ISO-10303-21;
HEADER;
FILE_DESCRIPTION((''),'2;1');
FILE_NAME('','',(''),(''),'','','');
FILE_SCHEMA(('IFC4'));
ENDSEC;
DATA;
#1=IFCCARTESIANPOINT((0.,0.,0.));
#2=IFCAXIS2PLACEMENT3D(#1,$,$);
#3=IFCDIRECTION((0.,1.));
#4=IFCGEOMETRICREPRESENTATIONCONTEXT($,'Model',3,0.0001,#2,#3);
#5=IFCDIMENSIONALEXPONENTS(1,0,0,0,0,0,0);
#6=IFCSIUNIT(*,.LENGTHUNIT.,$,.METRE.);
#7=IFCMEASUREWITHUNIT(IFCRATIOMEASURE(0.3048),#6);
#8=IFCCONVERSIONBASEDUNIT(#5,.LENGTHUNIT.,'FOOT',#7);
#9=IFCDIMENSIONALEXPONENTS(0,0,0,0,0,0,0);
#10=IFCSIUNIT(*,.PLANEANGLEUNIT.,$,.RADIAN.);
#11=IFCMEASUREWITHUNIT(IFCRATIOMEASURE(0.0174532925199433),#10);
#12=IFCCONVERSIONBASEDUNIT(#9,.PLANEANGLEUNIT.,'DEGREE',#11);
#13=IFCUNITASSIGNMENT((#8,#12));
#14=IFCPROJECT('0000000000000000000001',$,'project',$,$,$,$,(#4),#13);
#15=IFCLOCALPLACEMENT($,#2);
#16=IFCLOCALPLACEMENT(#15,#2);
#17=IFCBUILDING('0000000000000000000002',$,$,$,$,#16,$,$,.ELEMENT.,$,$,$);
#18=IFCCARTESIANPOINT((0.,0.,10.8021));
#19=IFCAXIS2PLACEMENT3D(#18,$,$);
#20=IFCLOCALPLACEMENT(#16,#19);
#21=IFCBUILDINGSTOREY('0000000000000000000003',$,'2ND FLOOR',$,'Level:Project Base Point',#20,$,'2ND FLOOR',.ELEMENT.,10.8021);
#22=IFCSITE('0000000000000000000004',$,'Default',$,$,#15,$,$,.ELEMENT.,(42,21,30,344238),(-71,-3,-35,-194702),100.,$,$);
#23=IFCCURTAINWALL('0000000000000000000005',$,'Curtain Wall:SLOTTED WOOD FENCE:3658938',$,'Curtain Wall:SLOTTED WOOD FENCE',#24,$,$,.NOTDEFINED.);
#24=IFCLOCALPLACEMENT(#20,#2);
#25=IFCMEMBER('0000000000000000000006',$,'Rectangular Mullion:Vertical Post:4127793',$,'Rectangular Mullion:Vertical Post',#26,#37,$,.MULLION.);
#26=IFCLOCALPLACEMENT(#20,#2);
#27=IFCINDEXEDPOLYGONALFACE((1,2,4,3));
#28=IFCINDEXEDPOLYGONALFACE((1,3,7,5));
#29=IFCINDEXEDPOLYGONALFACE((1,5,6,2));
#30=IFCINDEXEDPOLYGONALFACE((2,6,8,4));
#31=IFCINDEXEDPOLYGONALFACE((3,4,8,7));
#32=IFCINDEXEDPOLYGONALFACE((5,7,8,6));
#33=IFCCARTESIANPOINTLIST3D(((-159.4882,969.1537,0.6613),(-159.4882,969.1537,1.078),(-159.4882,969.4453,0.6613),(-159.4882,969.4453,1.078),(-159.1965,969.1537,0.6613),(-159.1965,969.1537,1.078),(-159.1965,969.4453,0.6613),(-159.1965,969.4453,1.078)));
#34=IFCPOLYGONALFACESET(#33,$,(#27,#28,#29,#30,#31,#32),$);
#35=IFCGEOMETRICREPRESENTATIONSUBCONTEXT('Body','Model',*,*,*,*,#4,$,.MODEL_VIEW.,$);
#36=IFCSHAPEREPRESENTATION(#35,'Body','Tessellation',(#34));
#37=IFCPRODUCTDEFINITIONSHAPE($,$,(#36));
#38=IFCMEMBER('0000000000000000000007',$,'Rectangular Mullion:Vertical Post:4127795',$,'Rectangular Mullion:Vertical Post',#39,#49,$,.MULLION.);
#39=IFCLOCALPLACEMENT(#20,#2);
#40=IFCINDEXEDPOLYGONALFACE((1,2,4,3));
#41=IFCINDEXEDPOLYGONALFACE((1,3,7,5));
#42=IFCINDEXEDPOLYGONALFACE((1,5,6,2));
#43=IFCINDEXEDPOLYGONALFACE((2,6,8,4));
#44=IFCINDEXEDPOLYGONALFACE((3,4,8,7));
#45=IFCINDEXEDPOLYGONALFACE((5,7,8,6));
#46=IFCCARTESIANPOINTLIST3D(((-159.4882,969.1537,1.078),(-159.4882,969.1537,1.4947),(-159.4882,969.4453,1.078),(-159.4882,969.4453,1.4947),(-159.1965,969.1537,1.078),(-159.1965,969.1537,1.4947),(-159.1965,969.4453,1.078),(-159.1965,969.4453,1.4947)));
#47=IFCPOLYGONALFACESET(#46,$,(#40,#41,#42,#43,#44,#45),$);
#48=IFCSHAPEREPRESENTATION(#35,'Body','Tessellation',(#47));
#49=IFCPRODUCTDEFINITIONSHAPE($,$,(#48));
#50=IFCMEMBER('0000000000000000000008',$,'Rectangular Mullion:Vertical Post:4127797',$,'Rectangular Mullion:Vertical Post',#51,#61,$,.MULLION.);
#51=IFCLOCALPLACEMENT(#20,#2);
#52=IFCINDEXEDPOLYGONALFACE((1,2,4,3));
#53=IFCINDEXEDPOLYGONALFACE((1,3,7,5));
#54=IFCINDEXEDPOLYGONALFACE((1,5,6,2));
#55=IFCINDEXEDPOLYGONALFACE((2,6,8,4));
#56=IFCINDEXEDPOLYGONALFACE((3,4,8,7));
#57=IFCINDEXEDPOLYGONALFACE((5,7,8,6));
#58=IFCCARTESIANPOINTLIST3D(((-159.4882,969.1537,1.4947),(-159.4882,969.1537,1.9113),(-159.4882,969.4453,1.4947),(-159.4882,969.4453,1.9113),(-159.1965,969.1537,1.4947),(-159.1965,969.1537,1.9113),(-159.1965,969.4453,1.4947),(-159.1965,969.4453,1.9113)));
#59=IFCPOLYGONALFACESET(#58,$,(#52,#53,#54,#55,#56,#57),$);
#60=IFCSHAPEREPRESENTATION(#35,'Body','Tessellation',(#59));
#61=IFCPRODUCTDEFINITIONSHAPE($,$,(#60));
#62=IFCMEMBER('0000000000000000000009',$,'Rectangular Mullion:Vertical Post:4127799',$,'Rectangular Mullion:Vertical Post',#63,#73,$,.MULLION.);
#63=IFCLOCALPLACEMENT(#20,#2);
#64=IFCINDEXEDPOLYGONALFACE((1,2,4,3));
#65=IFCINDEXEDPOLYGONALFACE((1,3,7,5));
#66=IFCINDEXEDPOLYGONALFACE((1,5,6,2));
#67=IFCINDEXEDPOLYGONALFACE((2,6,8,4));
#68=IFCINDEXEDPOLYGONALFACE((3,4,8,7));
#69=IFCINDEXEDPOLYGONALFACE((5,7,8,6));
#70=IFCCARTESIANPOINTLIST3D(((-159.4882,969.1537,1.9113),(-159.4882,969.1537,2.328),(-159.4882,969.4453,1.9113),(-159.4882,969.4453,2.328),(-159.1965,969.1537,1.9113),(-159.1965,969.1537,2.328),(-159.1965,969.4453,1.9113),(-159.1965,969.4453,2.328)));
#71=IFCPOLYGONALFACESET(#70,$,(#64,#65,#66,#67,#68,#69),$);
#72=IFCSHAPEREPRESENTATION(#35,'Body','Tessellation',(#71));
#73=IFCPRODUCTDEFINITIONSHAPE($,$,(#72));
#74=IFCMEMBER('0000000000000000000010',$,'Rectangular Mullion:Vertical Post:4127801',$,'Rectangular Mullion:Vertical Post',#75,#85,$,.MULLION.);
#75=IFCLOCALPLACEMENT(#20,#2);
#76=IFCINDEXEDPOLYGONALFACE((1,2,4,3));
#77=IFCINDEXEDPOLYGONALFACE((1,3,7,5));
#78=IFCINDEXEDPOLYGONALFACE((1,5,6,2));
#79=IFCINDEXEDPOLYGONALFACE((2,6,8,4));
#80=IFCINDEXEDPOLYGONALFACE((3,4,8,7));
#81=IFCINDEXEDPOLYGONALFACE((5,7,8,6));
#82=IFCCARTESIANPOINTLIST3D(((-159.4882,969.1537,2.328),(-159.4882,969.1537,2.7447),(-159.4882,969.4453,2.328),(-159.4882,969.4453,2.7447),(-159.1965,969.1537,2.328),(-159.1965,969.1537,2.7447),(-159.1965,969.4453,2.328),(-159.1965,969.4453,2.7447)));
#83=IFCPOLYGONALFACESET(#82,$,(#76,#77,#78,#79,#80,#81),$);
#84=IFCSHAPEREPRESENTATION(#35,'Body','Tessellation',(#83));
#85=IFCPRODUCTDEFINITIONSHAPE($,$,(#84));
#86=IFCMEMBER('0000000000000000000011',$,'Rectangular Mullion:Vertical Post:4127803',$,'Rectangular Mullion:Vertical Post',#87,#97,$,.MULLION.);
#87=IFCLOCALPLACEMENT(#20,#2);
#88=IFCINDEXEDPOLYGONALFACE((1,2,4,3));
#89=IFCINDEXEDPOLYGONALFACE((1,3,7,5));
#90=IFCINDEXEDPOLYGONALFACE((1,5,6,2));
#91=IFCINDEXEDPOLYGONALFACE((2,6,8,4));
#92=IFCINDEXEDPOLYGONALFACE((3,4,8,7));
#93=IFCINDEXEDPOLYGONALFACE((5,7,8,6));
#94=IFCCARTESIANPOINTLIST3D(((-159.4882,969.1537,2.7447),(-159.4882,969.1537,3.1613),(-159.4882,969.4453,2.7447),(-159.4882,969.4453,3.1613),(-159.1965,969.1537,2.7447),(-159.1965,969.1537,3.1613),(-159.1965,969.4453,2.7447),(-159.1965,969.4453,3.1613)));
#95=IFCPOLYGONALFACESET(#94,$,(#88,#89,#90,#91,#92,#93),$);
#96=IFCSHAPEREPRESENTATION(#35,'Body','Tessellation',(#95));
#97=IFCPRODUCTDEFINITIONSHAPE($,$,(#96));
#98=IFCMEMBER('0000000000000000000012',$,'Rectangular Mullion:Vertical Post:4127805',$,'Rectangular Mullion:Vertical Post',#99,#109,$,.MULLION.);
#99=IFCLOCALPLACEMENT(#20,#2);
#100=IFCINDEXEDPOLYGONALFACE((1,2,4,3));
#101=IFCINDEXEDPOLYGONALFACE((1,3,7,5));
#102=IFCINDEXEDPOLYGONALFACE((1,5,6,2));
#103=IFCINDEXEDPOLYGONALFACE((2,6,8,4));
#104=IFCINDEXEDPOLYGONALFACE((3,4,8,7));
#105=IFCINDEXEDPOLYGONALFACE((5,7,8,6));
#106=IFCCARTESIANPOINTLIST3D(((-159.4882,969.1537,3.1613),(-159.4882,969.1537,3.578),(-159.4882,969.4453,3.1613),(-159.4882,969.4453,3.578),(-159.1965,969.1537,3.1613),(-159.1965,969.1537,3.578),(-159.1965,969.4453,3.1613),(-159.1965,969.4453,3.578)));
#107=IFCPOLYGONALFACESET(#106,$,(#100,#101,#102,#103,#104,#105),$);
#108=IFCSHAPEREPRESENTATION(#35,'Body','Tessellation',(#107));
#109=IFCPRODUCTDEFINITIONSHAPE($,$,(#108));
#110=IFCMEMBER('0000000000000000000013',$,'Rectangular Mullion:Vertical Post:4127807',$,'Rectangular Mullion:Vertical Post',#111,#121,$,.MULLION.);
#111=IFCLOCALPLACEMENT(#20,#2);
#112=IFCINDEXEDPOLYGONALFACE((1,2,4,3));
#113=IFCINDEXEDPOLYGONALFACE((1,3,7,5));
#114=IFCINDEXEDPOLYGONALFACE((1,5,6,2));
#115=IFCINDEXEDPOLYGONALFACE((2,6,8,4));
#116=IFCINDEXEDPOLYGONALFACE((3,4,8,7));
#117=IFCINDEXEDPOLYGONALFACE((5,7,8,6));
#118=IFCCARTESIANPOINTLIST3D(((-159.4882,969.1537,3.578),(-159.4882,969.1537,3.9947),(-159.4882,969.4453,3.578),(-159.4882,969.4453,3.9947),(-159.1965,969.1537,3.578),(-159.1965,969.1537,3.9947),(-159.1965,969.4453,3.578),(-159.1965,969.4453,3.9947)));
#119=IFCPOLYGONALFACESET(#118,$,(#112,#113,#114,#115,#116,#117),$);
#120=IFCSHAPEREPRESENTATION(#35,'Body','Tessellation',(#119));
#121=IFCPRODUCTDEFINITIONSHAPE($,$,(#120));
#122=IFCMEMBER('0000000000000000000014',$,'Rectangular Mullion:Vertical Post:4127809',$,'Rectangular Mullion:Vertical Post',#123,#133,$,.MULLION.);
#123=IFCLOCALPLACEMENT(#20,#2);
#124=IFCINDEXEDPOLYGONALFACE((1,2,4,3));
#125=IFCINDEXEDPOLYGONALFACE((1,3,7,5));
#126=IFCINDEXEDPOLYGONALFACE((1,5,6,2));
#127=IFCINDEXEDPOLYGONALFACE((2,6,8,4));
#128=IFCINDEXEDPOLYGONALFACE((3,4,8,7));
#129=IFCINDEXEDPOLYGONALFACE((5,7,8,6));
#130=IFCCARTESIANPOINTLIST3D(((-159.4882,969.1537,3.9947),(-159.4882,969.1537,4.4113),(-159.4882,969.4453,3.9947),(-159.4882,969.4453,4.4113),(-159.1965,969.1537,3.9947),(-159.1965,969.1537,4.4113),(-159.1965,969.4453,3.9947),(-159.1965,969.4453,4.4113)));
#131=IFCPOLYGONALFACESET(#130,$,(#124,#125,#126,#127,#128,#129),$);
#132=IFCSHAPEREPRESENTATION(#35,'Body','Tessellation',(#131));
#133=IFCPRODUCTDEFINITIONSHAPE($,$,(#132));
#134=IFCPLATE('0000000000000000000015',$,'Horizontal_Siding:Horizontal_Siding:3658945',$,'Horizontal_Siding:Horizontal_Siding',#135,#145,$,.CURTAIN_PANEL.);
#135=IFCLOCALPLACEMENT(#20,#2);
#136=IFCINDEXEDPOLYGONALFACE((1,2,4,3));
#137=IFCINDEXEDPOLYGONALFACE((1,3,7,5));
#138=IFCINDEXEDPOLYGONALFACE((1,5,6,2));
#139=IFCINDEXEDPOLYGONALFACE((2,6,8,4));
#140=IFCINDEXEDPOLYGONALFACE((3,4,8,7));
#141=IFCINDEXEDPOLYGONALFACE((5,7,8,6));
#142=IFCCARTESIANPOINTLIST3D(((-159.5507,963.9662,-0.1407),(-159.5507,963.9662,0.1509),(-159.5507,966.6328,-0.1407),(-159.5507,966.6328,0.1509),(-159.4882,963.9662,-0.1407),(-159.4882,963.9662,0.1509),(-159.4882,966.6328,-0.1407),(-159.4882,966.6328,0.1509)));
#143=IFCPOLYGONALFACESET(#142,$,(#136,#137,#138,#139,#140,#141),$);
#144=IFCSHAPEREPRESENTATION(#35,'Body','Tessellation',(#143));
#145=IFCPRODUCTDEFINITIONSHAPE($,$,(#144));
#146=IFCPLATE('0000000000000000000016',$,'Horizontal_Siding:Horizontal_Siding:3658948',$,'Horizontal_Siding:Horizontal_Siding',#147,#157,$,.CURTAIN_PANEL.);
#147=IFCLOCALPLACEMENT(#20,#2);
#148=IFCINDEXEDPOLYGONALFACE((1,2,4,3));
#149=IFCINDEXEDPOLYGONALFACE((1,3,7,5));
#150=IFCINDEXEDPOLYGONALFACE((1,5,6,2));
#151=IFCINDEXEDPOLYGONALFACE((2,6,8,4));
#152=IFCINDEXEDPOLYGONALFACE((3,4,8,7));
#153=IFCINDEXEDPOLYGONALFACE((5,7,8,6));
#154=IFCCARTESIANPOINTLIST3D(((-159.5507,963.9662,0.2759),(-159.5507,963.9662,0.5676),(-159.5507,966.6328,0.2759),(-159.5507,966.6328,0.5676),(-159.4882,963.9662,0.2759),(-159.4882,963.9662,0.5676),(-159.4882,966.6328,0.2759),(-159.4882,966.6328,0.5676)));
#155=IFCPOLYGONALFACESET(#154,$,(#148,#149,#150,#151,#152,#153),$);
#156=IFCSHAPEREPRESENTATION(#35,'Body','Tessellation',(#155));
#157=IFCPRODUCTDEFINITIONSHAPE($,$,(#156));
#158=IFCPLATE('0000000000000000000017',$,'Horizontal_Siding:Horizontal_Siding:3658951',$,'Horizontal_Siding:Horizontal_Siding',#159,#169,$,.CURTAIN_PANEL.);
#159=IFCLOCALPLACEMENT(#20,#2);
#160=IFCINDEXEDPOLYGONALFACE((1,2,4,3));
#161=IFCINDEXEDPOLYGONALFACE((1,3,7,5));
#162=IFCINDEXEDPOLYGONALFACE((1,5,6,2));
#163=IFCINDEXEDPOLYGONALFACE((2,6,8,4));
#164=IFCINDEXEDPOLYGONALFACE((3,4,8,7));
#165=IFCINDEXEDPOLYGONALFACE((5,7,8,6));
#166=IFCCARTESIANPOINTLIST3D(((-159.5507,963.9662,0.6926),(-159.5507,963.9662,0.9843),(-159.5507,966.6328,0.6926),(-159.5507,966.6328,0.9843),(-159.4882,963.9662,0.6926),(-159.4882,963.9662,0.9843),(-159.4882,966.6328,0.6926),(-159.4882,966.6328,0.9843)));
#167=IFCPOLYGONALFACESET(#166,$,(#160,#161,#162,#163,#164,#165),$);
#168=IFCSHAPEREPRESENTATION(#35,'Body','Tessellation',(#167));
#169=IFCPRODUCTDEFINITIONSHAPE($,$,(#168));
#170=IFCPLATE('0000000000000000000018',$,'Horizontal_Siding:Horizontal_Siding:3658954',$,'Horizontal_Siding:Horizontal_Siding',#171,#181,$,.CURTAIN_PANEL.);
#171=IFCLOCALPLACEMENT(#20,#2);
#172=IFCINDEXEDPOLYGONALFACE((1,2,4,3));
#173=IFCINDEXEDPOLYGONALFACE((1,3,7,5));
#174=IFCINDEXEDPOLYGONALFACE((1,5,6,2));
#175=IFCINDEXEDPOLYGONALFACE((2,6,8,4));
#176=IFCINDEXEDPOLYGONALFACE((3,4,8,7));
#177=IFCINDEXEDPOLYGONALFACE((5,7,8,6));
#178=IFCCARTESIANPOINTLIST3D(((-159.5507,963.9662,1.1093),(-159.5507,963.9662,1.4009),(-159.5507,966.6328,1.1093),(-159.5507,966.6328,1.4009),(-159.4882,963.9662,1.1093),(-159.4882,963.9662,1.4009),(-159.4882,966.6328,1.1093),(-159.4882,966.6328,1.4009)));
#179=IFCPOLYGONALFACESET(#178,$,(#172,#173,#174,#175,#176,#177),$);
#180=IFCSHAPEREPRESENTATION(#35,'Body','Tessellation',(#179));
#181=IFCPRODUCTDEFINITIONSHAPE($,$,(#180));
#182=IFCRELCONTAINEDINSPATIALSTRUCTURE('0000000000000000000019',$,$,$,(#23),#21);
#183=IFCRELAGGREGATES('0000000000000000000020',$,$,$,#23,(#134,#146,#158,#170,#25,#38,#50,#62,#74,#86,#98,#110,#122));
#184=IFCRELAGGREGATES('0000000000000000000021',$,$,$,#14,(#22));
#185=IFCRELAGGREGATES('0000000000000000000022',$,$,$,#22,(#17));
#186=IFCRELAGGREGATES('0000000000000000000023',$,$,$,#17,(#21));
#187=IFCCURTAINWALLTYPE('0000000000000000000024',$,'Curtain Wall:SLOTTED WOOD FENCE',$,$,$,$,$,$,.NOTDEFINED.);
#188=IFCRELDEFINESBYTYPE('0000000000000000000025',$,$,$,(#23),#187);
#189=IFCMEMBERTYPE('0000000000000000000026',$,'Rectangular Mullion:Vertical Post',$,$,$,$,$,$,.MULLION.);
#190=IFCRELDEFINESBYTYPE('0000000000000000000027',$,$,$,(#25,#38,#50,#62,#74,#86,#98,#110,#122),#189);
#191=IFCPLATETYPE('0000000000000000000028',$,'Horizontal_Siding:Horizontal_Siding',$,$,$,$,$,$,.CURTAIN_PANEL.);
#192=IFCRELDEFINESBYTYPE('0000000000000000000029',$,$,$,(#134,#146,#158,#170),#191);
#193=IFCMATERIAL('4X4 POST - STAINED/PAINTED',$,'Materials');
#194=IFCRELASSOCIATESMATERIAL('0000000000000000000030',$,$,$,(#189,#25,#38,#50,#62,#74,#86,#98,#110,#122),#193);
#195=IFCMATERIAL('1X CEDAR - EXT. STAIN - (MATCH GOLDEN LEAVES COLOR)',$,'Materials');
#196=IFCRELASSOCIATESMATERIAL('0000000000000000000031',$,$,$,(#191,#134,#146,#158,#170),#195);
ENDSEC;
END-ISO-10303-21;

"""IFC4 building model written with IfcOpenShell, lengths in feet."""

from ifc_helpers import new_model, entity, si_unit, converted_unit, direction, frame, origin, origin_2d_with_axis, place, context, subcontext, project, spatial, rectangle, extrude, source, transform, mapped, material, material_profile, profile_set, profile_usage, type_object, type_shapes, element, aggregate, save


model = new_model("IFC4")

# Units and contexts
model_context = context("Model", 3, precision=0.0001, world=origin(), true_north=direction((0.0, 1.0)))
body_context = subcontext(model_context, "Body", "Model", "MODEL_VIEW")
ifc_project = project(units=[converted_unit("LENGTHUNIT", "FOOT", entity("IfcRatioMeasure", 0.3048), si_unit("LENGTHUNIT", "METRE"), dimensions=[1, 0, 0, 0, 0, 0, 0]), converted_unit("PLANEANGLEUNIT", "DEGREE", entity("IfcRatioMeasure", 0.0174532925199433), si_unit("PLANEANGLEUNIT", "RADIAN"), dimensions=[0, 0, 0, 0, 0, 0, 0])], contexts=[model_context])

# Site, building, storey
site_placement = place(None, origin())
site = spatial("IfcSite", under=ifc_project, at=site_placement, Name="Default", CompositionType="ELEMENT", RefLatitude=(42, 21, 30, 344238), RefLongitude=(-71, -3, -35, -194702), RefElevation=100.0)
building_placement = place(site_placement, origin())
building = spatial("IfcBuilding", under=site, at=building_placement, CompositionType="ELEMENT")
storey_placement = place(building_placement, frame((0.0, 0.0, 10.8021)))
storey = spatial("IfcBuildingStorey", under=building, at=storey_placement, Name="2ND FLOOR", ObjectType="Level:Project Base Point", LongName="2ND FLOOR", CompositionType="ELEMENT", Elevation=10.8021)

# Curtain wall, members, plates
curtain_wall_type = type_object("IfcCurtainWallType", Name="Curtain Wall:SLOTTED WOOD FENCE", PredefinedType="NOTDEFINED")
curtain_wall_placement = place(storey_placement, frame((0.0, 0.0, -10.8021)))
curtain_wall = element("IfcCurtainWall", 1, at=curtain_wall_placement, inside=storey, type_object=curtain_wall_type, Name="Curtain Wall:SLOTTED WOOD FENCE:3658938", ObjectType="Curtain Wall:SLOTTED WOOD FENCE", PredefinedType="NOTDEFINED")
ifc_material_1 = material(Name="4X4 POST - STAINED/PAINTED", Category="Materials")
ifc_material_profile = material_profile(ifc_material_1, rectangle(XDim=0.2917, YDim=0.2917, at=origin_2d_with_axis()), Name="Vertical Post")
ifc_profile_set = profile_set([ifc_material_profile], Name="Vertical Post")
member_type_1 = type_object("IfcMemberType", Name="Rectangular Mullion:Vertical Post", PredefinedType="MULLION", material=ifc_profile_set)
shared_shape_1 = source(origin(), body_context, "Body", "SweptSolid", [
    extrude(rectangle(XDim=0.2917, YDim=0.2917, at=origin_2d_with_axis()), frame((0.0, -0.2083, -0.4167), z_axis=(0.0, 0.0, 1.0), x_axis=(0.0, -1.0, 0.0)), (0.0, 0.0, 1.0), 0.4167),
])
type_shapes(member_type_1, [shared_shape_1])
ifc_profile_usage_1 = profile_usage(ifc_profile_set)
member_1_placement = place(storey_placement, frame((-159.5507, 969.2995, 0.6613), z_axis=(0.0, 0.0, -1.0), x_axis=(0.0, -1.0, 0.0)))
member_1 = element("IfcMember", 2, at=member_1_placement, type_object=member_type_1, material=ifc_profile_usage_1, Name="Rectangular Mullion:Vertical Post:4127793", ObjectType="Rectangular Mullion:Vertical Post", PredefinedType="MULLION", context=body_context, shape_type="MappedRepresentation", body=[
    mapped(shared_shape_1, transform((0.0, 0.0, 0.0), scale=1.0)),
])
ifc_profile_usage_2 = profile_usage(ifc_profile_set)
member_2_placement = place(storey_placement, frame((-159.5507, 969.2995, 1.078), z_axis=(0.0, 0.0, -1.0), x_axis=(0.0, -1.0, 0.0)))
member_2 = element("IfcMember", 3, at=member_2_placement, type_object=member_type_1, material=ifc_profile_usage_2, Name="Rectangular Mullion:Vertical Post:4127795", ObjectType="Rectangular Mullion:Vertical Post", PredefinedType="MULLION", context=body_context, shape_type="MappedRepresentation", body=[
    mapped(shared_shape_1, transform((0.0, 0.0, 0.0), scale=1.0)),
])
ifc_profile_usage_3 = profile_usage(ifc_profile_set)
member_3_placement = place(storey_placement, frame((-159.5507, 969.2995, 1.4947), z_axis=(0.0, 0.0, -1.0), x_axis=(0.0, -1.0, 0.0)))
member_3 = element("IfcMember", 4, at=member_3_placement, type_object=member_type_1, material=ifc_profile_usage_3, Name="Rectangular Mullion:Vertical Post:4127797", ObjectType="Rectangular Mullion:Vertical Post", PredefinedType="MULLION", context=body_context, shape_type="MappedRepresentation", body=[
    mapped(shared_shape_1, transform((0.0, 0.0, 0.0), scale=1.0)),
])
ifc_profile_usage_4 = profile_usage(ifc_profile_set)
member_4_placement = place(storey_placement, frame((-159.5507, 969.2995, 1.9113), z_axis=(0.0, 0.0, -1.0), x_axis=(0.0, -1.0, 0.0)))
member_4 = element("IfcMember", 5, at=member_4_placement, type_object=member_type_1, material=ifc_profile_usage_4, Name="Rectangular Mullion:Vertical Post:4127799", ObjectType="Rectangular Mullion:Vertical Post", PredefinedType="MULLION", context=body_context, shape_type="MappedRepresentation", body=[
    mapped(shared_shape_1, transform((0.0, 0.0, 0.0), scale=1.0)),
])
ifc_profile_usage_5 = profile_usage(ifc_profile_set)
member_5_placement = place(storey_placement, frame((-159.5507, 969.2995, 2.328), z_axis=(0.0, 0.0, -1.0), x_axis=(0.0, -1.0, 0.0)))
member_5 = element("IfcMember", 6, at=member_5_placement, type_object=member_type_1, material=ifc_profile_usage_5, Name="Rectangular Mullion:Vertical Post:4127801", ObjectType="Rectangular Mullion:Vertical Post", PredefinedType="MULLION", context=body_context, shape_type="MappedRepresentation", body=[
    mapped(shared_shape_1, transform((0.0, 0.0, 0.0), scale=1.0)),
])
ifc_profile_usage_6 = profile_usage(ifc_profile_set)
member_6_placement = place(storey_placement, frame((-159.5507, 969.2995, 2.7447), z_axis=(0.0, 0.0, -1.0), x_axis=(0.0, -1.0, 0.0)))
member_6 = element("IfcMember", 7, at=member_6_placement, type_object=member_type_1, material=ifc_profile_usage_6, Name="Rectangular Mullion:Vertical Post:4127803", ObjectType="Rectangular Mullion:Vertical Post", PredefinedType="MULLION", context=body_context, shape_type="MappedRepresentation", body=[
    mapped(shared_shape_1, transform((0.0, 0.0, 0.0), scale=1.0)),
])
ifc_profile_usage_7 = profile_usage(ifc_profile_set)
member_7_placement = place(storey_placement, frame((-159.5507, 969.2995, 3.1613), z_axis=(0.0, 0.0, -1.0), x_axis=(0.0, -1.0, 0.0)))
member_7 = element("IfcMember", 8, at=member_7_placement, type_object=member_type_1, material=ifc_profile_usage_7, Name="Rectangular Mullion:Vertical Post:4127805", ObjectType="Rectangular Mullion:Vertical Post", PredefinedType="MULLION", context=body_context, shape_type="MappedRepresentation", body=[
    mapped(shared_shape_1, transform((0.0, 0.0, 0.0), scale=1.0)),
])
ifc_profile_usage_8 = profile_usage(ifc_profile_set)
member_8_placement = place(storey_placement, frame((-159.5507, 969.2995, 3.578), z_axis=(0.0, 0.0, -1.0), x_axis=(0.0, -1.0, 0.0)))
member_8 = element("IfcMember", 9, at=member_8_placement, type_object=member_type_1, material=ifc_profile_usage_8, Name="Rectangular Mullion:Vertical Post:4127807", ObjectType="Rectangular Mullion:Vertical Post", PredefinedType="MULLION", context=body_context, shape_type="MappedRepresentation", body=[
    mapped(shared_shape_1, transform((0.0, 0.0, 0.0), scale=1.0)),
])
ifc_profile_usage_9 = profile_usage(ifc_profile_set)
member_9_placement = place(storey_placement, frame((-159.5507, 969.2995, 3.9947), z_axis=(0.0, 0.0, -1.0), x_axis=(0.0, -1.0, 0.0)))
member_9 = element("IfcMember", 10, at=member_9_placement, type_object=member_type_1, material=ifc_profile_usage_9, Name="Rectangular Mullion:Vertical Post:4127809", ObjectType="Rectangular Mullion:Vertical Post", PredefinedType="MULLION", context=body_context, shape_type="MappedRepresentation", body=[
    mapped(shared_shape_1, transform((0.0, 0.0, 0.0), scale=1.0)),
])
ifc_material_2 = material(Name="1X CEDAR - EXT. STAIN - (MATCH GOLDEN LEAVES COLOR)", Category="Materials")
plate_type = type_object("IfcPlateType", Name="Horizontal_Siding:Horizontal_Siding", PredefinedType="CURTAIN_PANEL", material=ifc_material_2)
shared_shape_2 = source(origin(), body_context, "Body", "SweptSolid", [
    extrude(rectangle(XDim=2.6667, YDim=0.0625, at=origin_2d_with_axis()), frame((1.3333, 0.0312, 0.0), z_axis=(0.0, 0.0, 1.0), x_axis=(-1.0, 0.0, 0.0)), (0.0, 0.0, 1.0), 0.2917),
])
type_shapes(plate_type, [shared_shape_2])
plate_1_placement = place(curtain_wall_placement, frame((-159.5507, 966.6328, 10.6613), z_axis=(0.0, 0.0, 1.0), x_axis=(0.0, -1.0, 0.0)))
plate_1 = element("IfcPlate", 11, at=plate_1_placement, type_object=plate_type, material=ifc_material_2, Name="Horizontal_Siding:Horizontal_Siding:3658945", ObjectType="Horizontal_Siding:Horizontal_Siding", PredefinedType="CURTAIN_PANEL", context=body_context, shape_type="MappedRepresentation", body=[
    mapped(shared_shape_2, transform((0.0, 0.0, 0.0), scale=1.0)),
])
plate_2_placement = place(curtain_wall_placement, frame((-159.5507, 966.6328, 11.078), z_axis=(0.0, 0.0, 1.0), x_axis=(0.0, -1.0, 0.0)))
plate_2 = element("IfcPlate", 12, at=plate_2_placement, type_object=plate_type, material=ifc_material_2, Name="Horizontal_Siding:Horizontal_Siding:3658948", ObjectType="Horizontal_Siding:Horizontal_Siding", PredefinedType="CURTAIN_PANEL", context=body_context, shape_type="MappedRepresentation", body=[
    mapped(shared_shape_2, transform((0.0, 0.0, 0.0), scale=1.0)),
])
plate_3_placement = place(curtain_wall_placement, frame((-159.5507, 966.6328, 11.4947), z_axis=(0.0, 0.0, 1.0), x_axis=(0.0, -1.0, 0.0)))
plate_3 = element("IfcPlate", 13, at=plate_3_placement, type_object=plate_type, material=ifc_material_2, Name="Horizontal_Siding:Horizontal_Siding:3658951", ObjectType="Horizontal_Siding:Horizontal_Siding", PredefinedType="CURTAIN_PANEL", context=body_context, shape_type="MappedRepresentation", body=[
    mapped(shared_shape_2, transform((0.0, 0.0, 0.0), scale=1.0)),
])
plate_4_placement = place(curtain_wall_placement, frame((-159.5507, 966.6328, 11.9113), z_axis=(0.0, 0.0, 1.0), x_axis=(0.0, -1.0, 0.0)))
plate_4 = element("IfcPlate", 14, at=plate_4_placement, type_object=plate_type, material=ifc_material_2, Name="Horizontal_Siding:Horizontal_Siding:3658954", ObjectType="Horizontal_Siding:Horizontal_Siding", PredefinedType="CURTAIN_PANEL", context=body_context, shape_type="MappedRepresentation", body=[
    mapped(shared_shape_2, transform((0.0, 0.0, 0.0), scale=1.0)),
])
aggregate(curtain_wall, [plate_1, plate_2, plate_3, plate_4, member_1, member_2, member_3, member_4, member_5, member_6, member_7, member_8, member_9])

save(model, "model.ifc")
